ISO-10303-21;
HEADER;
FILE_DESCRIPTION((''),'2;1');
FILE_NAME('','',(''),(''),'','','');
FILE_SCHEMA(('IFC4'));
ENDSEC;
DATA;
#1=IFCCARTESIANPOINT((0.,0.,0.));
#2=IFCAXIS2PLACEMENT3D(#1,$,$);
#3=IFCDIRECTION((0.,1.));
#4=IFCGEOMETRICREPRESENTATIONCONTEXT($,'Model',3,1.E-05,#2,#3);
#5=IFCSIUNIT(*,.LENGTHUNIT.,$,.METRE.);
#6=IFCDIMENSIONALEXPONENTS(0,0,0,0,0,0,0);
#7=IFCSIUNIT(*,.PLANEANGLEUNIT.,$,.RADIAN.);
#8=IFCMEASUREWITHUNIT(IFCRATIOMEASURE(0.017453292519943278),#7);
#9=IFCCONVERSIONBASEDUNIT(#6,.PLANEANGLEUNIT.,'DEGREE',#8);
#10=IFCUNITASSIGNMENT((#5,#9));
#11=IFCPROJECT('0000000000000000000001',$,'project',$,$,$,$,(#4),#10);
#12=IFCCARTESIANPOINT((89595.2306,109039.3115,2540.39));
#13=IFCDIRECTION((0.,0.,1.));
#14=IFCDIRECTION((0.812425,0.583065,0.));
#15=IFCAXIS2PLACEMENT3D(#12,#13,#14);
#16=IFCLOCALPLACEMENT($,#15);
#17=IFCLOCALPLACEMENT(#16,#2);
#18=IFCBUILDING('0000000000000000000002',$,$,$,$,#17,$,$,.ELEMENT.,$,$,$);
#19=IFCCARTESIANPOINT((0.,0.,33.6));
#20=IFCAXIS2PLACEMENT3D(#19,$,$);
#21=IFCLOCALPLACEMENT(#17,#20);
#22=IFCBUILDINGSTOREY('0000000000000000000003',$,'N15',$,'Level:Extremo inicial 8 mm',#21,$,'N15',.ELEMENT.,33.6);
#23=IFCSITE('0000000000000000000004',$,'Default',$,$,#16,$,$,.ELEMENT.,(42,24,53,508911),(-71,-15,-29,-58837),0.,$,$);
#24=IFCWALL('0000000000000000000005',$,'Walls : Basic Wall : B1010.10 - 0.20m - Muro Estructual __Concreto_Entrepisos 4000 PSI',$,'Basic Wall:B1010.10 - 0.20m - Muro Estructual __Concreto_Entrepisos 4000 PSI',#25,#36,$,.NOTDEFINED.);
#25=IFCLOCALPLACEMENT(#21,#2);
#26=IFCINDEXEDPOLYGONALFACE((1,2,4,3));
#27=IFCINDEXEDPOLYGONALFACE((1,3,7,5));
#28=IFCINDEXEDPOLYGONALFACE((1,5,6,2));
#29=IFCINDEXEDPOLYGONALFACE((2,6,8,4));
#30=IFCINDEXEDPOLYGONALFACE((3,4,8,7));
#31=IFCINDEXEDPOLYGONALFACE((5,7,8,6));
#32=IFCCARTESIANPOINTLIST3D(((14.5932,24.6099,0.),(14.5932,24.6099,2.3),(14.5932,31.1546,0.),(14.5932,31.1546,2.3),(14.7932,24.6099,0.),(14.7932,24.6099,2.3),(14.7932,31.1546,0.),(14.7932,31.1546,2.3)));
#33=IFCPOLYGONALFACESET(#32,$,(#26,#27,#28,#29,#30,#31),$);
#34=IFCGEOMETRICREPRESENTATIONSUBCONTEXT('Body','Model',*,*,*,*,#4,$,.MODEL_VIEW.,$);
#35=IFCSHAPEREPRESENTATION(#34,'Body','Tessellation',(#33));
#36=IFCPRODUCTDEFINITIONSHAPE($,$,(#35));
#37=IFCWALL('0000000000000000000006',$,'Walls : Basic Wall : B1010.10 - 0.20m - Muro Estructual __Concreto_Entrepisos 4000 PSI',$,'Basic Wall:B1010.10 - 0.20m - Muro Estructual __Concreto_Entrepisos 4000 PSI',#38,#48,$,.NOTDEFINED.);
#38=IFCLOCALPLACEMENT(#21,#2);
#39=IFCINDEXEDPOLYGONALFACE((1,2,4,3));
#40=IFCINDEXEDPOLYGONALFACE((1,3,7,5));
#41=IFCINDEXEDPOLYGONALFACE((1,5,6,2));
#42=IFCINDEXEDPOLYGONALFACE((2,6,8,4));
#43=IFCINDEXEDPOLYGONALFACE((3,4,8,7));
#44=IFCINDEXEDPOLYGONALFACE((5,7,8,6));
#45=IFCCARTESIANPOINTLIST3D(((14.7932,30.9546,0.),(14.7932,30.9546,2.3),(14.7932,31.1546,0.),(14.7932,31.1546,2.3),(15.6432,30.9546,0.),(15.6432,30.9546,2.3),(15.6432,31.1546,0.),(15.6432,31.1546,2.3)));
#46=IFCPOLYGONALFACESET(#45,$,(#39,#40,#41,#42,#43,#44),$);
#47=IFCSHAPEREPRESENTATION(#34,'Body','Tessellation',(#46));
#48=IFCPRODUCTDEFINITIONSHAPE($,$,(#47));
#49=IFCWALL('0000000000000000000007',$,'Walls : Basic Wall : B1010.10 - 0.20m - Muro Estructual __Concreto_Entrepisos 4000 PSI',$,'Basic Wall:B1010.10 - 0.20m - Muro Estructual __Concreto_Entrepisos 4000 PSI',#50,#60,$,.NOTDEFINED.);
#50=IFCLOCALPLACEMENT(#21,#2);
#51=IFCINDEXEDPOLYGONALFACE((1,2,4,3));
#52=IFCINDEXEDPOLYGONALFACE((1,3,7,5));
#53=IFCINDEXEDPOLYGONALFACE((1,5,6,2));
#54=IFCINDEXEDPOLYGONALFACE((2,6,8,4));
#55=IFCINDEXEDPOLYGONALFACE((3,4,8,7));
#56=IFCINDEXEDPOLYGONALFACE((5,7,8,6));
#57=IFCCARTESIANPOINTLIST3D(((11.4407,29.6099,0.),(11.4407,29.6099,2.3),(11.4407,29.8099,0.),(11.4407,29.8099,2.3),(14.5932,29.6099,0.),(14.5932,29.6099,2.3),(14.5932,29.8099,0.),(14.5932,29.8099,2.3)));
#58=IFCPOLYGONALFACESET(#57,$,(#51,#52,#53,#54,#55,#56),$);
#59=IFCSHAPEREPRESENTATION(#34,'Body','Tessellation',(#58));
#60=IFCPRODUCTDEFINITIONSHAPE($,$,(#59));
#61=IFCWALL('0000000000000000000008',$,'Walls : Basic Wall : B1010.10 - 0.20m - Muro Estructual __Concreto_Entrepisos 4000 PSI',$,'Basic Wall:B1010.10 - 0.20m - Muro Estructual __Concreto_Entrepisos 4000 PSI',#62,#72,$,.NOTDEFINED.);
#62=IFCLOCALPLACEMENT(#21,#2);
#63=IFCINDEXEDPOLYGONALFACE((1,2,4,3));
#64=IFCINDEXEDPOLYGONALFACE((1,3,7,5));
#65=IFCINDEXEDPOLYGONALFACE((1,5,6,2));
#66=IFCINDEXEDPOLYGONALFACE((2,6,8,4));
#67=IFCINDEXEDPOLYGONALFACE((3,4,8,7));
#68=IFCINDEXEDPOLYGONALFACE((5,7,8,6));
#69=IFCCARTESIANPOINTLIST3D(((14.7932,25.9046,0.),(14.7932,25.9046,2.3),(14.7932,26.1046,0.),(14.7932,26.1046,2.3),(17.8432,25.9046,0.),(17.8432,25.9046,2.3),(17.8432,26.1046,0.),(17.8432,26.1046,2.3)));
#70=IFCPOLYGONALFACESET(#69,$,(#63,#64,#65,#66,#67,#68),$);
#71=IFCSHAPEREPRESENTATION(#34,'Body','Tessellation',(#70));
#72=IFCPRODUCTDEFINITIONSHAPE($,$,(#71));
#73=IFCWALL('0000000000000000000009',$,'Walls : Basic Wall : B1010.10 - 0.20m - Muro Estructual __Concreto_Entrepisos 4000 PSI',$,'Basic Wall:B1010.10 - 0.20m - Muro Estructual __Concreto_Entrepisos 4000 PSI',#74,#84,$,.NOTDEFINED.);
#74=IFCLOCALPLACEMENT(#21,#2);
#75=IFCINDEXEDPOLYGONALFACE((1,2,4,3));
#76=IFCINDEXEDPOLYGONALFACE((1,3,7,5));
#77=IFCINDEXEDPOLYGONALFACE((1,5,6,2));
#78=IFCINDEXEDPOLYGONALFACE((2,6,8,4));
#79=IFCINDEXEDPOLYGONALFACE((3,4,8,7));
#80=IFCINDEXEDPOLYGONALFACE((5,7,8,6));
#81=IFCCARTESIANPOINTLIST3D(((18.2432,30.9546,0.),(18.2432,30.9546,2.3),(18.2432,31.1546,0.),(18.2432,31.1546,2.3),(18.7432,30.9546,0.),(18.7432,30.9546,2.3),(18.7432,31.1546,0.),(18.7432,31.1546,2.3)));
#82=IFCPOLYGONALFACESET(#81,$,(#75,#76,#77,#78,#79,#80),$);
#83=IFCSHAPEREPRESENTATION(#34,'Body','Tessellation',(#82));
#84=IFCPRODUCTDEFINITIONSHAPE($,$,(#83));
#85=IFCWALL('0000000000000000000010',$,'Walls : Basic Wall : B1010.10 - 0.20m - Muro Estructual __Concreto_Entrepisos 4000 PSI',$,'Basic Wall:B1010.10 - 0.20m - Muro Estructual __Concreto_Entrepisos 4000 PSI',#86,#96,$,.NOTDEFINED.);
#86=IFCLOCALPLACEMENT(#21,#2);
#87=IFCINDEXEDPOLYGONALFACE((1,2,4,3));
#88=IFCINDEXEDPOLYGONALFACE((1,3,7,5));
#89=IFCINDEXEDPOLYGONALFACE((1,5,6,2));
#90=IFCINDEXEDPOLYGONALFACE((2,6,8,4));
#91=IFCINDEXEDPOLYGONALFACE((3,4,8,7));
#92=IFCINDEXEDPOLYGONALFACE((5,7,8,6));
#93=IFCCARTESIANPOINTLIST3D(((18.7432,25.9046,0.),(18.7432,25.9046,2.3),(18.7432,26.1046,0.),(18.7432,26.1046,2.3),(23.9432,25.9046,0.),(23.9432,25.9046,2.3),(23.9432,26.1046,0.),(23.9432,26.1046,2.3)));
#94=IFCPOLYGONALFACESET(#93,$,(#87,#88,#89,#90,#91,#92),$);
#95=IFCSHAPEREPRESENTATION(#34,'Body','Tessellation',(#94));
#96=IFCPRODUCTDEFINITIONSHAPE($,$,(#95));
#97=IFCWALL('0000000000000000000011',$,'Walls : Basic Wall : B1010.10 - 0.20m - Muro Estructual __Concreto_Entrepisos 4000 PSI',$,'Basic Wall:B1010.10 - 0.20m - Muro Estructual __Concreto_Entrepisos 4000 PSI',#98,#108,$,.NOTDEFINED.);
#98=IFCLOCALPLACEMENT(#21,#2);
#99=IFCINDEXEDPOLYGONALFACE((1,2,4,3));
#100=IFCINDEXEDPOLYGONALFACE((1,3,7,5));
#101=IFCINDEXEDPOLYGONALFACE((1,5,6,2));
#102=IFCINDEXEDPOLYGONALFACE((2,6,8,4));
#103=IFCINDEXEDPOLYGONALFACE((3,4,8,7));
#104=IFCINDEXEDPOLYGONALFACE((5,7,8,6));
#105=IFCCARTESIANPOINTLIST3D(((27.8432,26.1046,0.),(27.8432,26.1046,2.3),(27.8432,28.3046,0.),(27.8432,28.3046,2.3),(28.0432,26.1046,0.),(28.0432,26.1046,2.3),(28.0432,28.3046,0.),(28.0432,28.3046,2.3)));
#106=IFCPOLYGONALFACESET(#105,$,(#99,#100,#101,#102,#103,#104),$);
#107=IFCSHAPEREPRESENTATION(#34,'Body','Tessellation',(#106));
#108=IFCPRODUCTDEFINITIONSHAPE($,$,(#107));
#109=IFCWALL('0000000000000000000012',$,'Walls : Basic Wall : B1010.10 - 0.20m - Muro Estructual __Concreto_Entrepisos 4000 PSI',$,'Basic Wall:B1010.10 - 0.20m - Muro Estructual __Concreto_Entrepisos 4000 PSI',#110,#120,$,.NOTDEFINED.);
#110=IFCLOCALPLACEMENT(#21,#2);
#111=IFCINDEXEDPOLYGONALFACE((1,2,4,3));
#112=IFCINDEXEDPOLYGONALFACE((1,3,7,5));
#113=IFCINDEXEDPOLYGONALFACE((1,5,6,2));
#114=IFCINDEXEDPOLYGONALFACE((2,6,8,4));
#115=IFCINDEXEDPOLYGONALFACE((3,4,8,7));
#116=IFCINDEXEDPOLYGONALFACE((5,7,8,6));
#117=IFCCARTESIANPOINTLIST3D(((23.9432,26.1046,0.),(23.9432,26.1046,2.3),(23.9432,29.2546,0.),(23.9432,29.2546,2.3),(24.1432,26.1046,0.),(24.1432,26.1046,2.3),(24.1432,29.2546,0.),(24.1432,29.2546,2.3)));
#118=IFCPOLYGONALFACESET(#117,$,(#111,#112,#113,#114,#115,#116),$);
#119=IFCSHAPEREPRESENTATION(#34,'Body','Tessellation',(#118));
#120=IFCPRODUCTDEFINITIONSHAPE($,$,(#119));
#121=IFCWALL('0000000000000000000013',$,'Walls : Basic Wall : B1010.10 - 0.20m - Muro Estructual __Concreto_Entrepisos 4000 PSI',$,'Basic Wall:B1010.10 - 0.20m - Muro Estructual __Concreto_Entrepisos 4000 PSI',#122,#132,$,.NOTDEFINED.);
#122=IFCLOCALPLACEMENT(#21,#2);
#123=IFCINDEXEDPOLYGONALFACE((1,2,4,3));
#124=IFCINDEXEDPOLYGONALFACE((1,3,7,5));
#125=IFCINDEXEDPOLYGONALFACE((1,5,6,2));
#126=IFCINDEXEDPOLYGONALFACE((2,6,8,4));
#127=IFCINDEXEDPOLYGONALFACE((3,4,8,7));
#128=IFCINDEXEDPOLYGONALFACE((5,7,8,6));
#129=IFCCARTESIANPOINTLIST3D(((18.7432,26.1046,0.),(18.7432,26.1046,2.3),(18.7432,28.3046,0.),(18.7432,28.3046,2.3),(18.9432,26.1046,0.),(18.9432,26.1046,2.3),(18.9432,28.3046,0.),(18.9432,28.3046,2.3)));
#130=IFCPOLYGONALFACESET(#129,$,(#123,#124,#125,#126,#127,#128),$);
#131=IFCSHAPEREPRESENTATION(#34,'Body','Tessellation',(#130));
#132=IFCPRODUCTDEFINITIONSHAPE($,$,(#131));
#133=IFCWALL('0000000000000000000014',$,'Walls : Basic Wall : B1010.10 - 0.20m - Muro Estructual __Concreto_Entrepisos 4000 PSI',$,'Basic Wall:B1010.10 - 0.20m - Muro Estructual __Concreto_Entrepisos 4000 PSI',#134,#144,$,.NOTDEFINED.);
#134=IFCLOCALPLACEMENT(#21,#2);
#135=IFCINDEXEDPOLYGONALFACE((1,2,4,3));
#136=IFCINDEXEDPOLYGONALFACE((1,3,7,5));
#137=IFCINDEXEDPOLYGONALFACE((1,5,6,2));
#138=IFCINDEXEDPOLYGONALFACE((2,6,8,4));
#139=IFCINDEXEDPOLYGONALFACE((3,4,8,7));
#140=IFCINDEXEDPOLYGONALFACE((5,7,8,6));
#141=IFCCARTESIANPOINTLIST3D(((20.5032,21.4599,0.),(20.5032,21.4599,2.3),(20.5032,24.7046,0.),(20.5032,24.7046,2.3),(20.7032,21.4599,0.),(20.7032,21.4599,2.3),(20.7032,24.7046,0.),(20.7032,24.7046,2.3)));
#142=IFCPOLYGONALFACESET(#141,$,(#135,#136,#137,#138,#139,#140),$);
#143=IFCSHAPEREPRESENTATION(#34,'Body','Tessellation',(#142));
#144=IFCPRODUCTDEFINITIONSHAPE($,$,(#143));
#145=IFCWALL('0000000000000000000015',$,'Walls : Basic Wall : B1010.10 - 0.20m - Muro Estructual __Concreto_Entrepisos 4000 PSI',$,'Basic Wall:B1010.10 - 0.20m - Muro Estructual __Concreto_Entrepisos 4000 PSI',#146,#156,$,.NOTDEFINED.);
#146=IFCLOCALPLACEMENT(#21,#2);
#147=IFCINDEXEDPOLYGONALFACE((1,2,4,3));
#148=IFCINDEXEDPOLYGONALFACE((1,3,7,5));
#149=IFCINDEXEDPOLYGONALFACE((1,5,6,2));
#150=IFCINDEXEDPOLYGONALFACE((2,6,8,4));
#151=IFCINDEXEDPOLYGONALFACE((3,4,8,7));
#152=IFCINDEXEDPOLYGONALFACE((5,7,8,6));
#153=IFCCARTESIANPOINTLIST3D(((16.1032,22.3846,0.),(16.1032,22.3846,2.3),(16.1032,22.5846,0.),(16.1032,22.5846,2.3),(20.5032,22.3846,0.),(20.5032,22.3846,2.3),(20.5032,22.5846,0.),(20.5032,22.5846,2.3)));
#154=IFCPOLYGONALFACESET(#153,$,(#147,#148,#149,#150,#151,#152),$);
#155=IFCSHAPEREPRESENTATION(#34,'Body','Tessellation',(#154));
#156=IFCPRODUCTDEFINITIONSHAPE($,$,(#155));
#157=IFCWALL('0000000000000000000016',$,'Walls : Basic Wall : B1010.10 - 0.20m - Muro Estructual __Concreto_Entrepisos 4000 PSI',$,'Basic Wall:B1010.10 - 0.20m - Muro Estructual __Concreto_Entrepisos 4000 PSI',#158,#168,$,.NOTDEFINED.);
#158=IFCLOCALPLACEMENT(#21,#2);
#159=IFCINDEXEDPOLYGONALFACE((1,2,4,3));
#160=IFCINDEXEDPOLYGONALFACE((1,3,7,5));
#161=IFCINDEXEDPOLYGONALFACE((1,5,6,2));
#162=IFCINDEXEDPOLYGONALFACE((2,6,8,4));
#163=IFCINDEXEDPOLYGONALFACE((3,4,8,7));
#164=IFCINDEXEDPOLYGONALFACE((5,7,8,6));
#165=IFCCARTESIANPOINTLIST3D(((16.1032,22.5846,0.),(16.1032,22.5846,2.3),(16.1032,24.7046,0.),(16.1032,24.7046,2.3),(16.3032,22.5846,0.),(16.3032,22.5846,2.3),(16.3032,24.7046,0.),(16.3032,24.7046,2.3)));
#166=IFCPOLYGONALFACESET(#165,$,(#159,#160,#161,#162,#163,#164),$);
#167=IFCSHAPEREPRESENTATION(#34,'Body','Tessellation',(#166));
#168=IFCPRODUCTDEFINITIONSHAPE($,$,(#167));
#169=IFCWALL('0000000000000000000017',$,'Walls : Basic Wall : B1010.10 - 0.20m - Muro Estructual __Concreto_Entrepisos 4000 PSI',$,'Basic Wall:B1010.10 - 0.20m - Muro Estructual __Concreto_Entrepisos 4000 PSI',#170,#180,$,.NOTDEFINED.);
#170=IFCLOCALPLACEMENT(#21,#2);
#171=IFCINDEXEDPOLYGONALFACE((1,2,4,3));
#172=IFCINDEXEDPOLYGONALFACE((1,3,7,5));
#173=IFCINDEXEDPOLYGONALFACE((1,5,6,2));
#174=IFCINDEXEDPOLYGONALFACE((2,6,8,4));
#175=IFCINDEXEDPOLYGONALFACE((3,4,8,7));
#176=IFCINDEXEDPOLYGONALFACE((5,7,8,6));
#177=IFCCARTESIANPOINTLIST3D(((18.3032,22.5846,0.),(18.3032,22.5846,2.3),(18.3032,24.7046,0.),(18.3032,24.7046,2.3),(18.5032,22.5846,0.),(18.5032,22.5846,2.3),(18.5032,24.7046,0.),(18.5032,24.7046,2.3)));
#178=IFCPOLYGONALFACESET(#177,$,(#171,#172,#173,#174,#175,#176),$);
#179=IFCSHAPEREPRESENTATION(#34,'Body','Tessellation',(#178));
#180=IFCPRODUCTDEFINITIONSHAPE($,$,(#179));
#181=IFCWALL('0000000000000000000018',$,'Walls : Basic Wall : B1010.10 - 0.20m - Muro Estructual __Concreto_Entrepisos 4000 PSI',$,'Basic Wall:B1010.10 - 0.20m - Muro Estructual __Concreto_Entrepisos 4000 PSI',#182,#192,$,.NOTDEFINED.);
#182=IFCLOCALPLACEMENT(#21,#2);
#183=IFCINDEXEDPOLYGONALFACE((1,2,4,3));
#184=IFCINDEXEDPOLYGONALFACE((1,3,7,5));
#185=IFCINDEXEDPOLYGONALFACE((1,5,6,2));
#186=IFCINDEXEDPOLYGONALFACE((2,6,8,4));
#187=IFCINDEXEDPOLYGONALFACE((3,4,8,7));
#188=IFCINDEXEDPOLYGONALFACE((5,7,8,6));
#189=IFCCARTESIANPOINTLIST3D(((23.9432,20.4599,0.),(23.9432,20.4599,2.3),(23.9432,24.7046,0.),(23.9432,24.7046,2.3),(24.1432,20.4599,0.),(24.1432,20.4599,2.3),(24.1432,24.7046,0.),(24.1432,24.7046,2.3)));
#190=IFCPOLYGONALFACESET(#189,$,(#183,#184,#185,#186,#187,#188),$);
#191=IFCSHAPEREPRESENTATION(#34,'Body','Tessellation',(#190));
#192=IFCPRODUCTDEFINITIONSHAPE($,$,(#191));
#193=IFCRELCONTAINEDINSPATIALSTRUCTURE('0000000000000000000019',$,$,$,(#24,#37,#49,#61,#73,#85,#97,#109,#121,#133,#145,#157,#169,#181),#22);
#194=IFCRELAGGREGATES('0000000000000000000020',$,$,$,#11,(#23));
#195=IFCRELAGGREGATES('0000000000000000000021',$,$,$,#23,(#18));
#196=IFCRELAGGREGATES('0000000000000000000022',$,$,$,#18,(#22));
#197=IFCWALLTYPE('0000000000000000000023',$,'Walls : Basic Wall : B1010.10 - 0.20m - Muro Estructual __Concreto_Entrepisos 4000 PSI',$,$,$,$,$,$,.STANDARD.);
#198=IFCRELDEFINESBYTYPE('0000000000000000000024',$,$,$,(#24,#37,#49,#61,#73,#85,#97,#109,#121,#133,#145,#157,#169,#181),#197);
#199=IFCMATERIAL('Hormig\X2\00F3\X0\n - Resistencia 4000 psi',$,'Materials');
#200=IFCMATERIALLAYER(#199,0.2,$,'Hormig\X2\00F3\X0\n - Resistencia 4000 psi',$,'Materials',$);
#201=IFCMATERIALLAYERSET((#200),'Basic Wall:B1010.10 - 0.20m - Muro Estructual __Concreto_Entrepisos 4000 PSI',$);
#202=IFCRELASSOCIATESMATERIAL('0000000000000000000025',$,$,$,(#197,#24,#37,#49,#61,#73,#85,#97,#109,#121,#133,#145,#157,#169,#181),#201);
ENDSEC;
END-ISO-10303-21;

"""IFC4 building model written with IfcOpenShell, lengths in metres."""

from ifc_helpers import new_model, entity, si_unit, converted_unit, direction, frame, frame_2d, origin, place, context, subcontext, project, spatial, rectangle, extrude, material, layer, layer_set, layer_usage, type_object, element, save


model = new_model("IFC4")

# Units and contexts
model_context = context("Model", 3, precision=1e-05, world=origin(), true_north=direction((0.0, 1.0)))
body_context = subcontext(model_context, "Body", "Model", "MODEL_VIEW")
ifc_project = project(units=[si_unit("LENGTHUNIT", "METRE"), converted_unit("PLANEANGLEUNIT", "DEGREE", entity("IfcRatioMeasure", 0.017453292519943278), si_unit("PLANEANGLEUNIT", "RADIAN"), dimensions=[0, 0, 0, 0, 0, 0, 0])], contexts=[model_context])

# Site, building, storey
site_placement = place(None, frame((89595.2306, 109039.3115, 2540.39), z_axis=(0.0, 0.0, 1.0), x_axis=(0.812425, 0.583065, 0.0)))
site = spatial("IfcSite", under=ifc_project, at=site_placement, Name="Default", CompositionType="ELEMENT", RefLatitude=(42, 24, 53, 508911), RefLongitude=(-71, -15, -29, -58837), RefElevation=0.0)
building_placement = place(site_placement, origin())
building = spatial("IfcBuilding", under=site, at=building_placement, CompositionType="ELEMENT")
storey_placement = place(building_placement, frame((0.0, 0.0, 33.6)))
storey = spatial("IfcBuildingStorey", under=building, at=storey_placement, Name="N15", ObjectType="Level:Extremo inicial 8 mm", LongName="N15", CompositionType="ELEMENT", Elevation=33.6)

# Walls
ifc_material_1 = material(Name="Hormigón - Resistencia 4000 psi", Category="Materials")
ifc_layer_1 = layer(ifc_material_1, 0.2, Name="Hormigón - Resistencia 4000 psi", Category="Materials")
ifc_layer_set_1 = layer_set([ifc_layer_1], Name="Basic Wall:B1010.10 - 0.20m - Muro Estructual __Concreto_Entrepisos 4000 PSI")
ifc_layer_usage_1 = layer_usage(ifc_layer_set_1, "AXIS2", "NEGATIVE", 0.1)
wall_type_1 = type_object("IfcWallType", Name="Walls : Basic Wall : B1010.10 - 0.20m - Muro Estructual __Concreto_Entrepisos 4000 PSI", PredefinedType="STANDARD", material=ifc_layer_set_1)
wall_1_placement = place(storey_placement, frame((14.6932, 24.6099, 0.0), z_axis=(0.0, 0.0, 1.0), x_axis=(0.0, 1.0, 0.0)))
element("IfcWall", 1, at=wall_1_placement, inside=storey, type_object=wall_type_1, material=ifc_layer_usage_1, Name="Walls : Basic Wall : B1010.10 - 0.20m - Muro Estructual __Concreto_Entrepisos 4000 PSI", ObjectType="Basic Wall:B1010.10 - 0.20m - Muro Estructual __Concreto_Entrepisos 4000 PSI", PredefinedType="NOTDEFINED", context=body_context, shape_type="SweptSolid", body=[
    extrude(rectangle(XDim=6.5447, YDim=0.2, at=frame_2d((3.2724, 0.0), x_axis=(-1.0, 0.0))), origin(), (0.0, 0.0, 1.0), 2.3),
])
ifc_layer_usage_2 = layer_usage(ifc_layer_set_1, "AXIS2", "NEGATIVE", 0.1)
wall_2_placement = place(storey_placement, frame((15.6432, 31.0546, 0.0), z_axis=(0.0, 0.0, 1.0), x_axis=(-1.0, 0.0, 0.0)))
element("IfcWall", 2, at=wall_2_placement, inside=storey, type_object=wall_type_1, material=ifc_layer_usage_2, Name="Walls : Basic Wall : B1010.10 - 0.20m - Muro Estructual __Concreto_Entrepisos 4000 PSI", ObjectType="Basic Wall:B1010.10 - 0.20m - Muro Estructual __Concreto_Entrepisos 4000 PSI", PredefinedType="NOTDEFINED", context=body_context, shape_type="SweptSolid", body=[
    extrude(rectangle(XDim=0.85, YDim=0.2, at=frame_2d((0.425, 0.0), x_axis=(-1.0, 0.0))), origin(), (0.0, 0.0, 1.0), 2.3),
])
ifc_layer_usage_3 = layer_usage(ifc_layer_set_1, "AXIS2", "NEGATIVE", 0.1)
wall_3_placement = place(storey_placement, frame((11.4407, 29.7099, 0.0)))
element("IfcWall", 3, at=wall_3_placement, inside=storey, type_object=wall_type_1, material=ifc_layer_usage_3, Name="Walls : Basic Wall : B1010.10 - 0.20m - Muro Estructual __Concreto_Entrepisos 4000 PSI", ObjectType="Basic Wall:B1010.10 - 0.20m - Muro Estructual __Concreto_Entrepisos 4000 PSI", PredefinedType="NOTDEFINED", context=body_context, shape_type="SweptSolid", body=[
    extrude(rectangle(XDim=3.1525, YDim=0.2, at=frame_2d((1.5763, 0.0), x_axis=(-1.0, 0.0))), origin(), (0.0, 0.0, 1.0), 2.3),
])
ifc_layer_usage_4 = layer_usage(ifc_layer_set_1, "AXIS2", "NEGATIVE", 0.1)
wall_4_placement = place(storey_placement, frame((17.8432, 26.0046, 0.0), z_axis=(0.0, 0.0, 1.0), x_axis=(-1.0, 0.0, 0.0)))
element("IfcWall", 4, at=wall_4_placement, inside=storey, type_object=wall_type_1, material=ifc_layer_usage_4, Name="Walls : Basic Wall : B1010.10 - 0.20m - Muro Estructual __Concreto_Entrepisos 4000 PSI", ObjectType="Basic Wall:B1010.10 - 0.20m - Muro Estructual __Concreto_Entrepisos 4000 PSI", PredefinedType="NOTDEFINED", context=body_context, shape_type="SweptSolid", body=[
    extrude(rectangle(XDim=3.05, YDim=0.2, at=frame_2d((1.525, 0.0), x_axis=(-1.0, 0.0))), origin(), (0.0, 0.0, 1.0), 2.3),
])
ifc_layer_usage_5 = layer_usage(ifc_layer_set_1, "AXIS2", "NEGATIVE", 0.1)
wall_5_placement = place(storey_placement, frame((18.7432, 31.0546, 0.0), z_axis=(0.0, 0.0, 1.0), x_axis=(-1.0, 0.0, 0.0)))
element("IfcWall", 5, at=wall_5_placement, inside=storey, type_object=wall_type_1, material=ifc_layer_usage_5, Name="Walls : Basic Wall : B1010.10 - 0.20m - Muro Estructual __Concreto_Entrepisos 4000 PSI", ObjectType="Basic Wall:B1010.10 - 0.20m - Muro Estructual __Concreto_Entrepisos 4000 PSI", PredefinedType="NOTDEFINED", context=body_context, shape_type="SweptSolid", body=[
    extrude(rectangle(XDim=0.5, YDim=0.2, at=frame_2d((0.25, 0.0), x_axis=(-1.0, 0.0))), origin(), (0.0, 0.0, 1.0), 2.3),
])
ifc_layer_usage_6 = layer_usage(ifc_layer_set_1, "AXIS2", "NEGATIVE", 0.1)
wall_6_placement = place(storey_placement, frame((18.7432, 26.0046, 0.0)))
element("IfcWall", 6, at=wall_6_placement, inside=storey, type_object=wall_type_1, material=ifc_layer_usage_6, Name="Walls : Basic Wall : B1010.10 - 0.20m - Muro Estructual __Concreto_Entrepisos 4000 PSI", ObjectType="Basic Wall:B1010.10 - 0.20m - Muro Estructual __Concreto_Entrepisos 4000 PSI", PredefinedType="NOTDEFINED", context=body_context, shape_type="SweptSolid", body=[
    extrude(rectangle(XDim=5.2, YDim=0.2, at=frame_2d((2.6, 0.0), x_axis=(-1.0, 0.0))), origin(), (0.0, 0.0, 1.0), 2.3),
])
ifc_layer_usage_7 = layer_usage(ifc_layer_set_1, "AXIS2", "NEGATIVE", 0.1)
wall_7_placement = place(storey_placement, frame((27.9432, 28.3046, 0.0), z_axis=(0.0, 0.0, 1.0), x_axis=(0.0, -1.0, 0.0)))
element("IfcWall", 7, at=wall_7_placement, inside=storey, type_object=wall_type_1, material=ifc_layer_usage_7, Name="Walls : Basic Wall : B1010.10 - 0.20m - Muro Estructual __Concreto_Entrepisos 4000 PSI", ObjectType="Basic Wall:B1010.10 - 0.20m - Muro Estructual __Concreto_Entrepisos 4000 PSI", PredefinedType="NOTDEFINED", context=body_context, shape_type="SweptSolid", body=[
    extrude(rectangle(XDim=2.2, YDim=0.2, at=frame_2d((1.1, 0.0), x_axis=(-1.0, 0.0))), origin(), (0.0, 0.0, 1.0), 2.3),
])
ifc_layer_usage_8 = layer_usage(ifc_layer_set_1, "AXIS2", "NEGATIVE", 0.1)
wall_8_placement = place(storey_placement, frame((24.0432, 26.1046, 0.0), z_axis=(0.0, 0.0, 1.0), x_axis=(0.0, 1.0, 0.0)))
element("IfcWall", 8, at=wall_8_placement, inside=storey, type_object=wall_type_1, material=ifc_layer_usage_8, Name="Walls : Basic Wall : B1010.10 - 0.20m - Muro Estructual __Concreto_Entrepisos 4000 PSI", ObjectType="Basic Wall:B1010.10 - 0.20m - Muro Estructual __Concreto_Entrepisos 4000 PSI", PredefinedType="NOTDEFINED", context=body_context, shape_type="SweptSolid", body=[
    extrude(rectangle(XDim=3.15, YDim=0.2, at=frame_2d((1.575, 0.0), x_axis=(-1.0, 0.0))), origin(), (0.0, 0.0, 1.0), 2.3),
])
ifc_layer_usage_9 = layer_usage(ifc_layer_set_1, "AXIS2", "NEGATIVE", 0.1)
wall_9_placement = place(storey_placement, frame((18.8432, 28.3046, 0.0), z_axis=(0.0, 0.0, 1.0), x_axis=(0.0, -1.0, 0.0)))
element("IfcWall", 9, at=wall_9_placement, inside=storey, type_object=wall_type_1, material=ifc_layer_usage_9, Name="Walls : Basic Wall : B1010.10 - 0.20m - Muro Estructual __Concreto_Entrepisos 4000 PSI", ObjectType="Basic Wall:B1010.10 - 0.20m - Muro Estructual __Concreto_Entrepisos 4000 PSI", PredefinedType="NOTDEFINED", context=body_context, shape_type="SweptSolid", body=[
    extrude(rectangle(XDim=2.2, YDim=0.2, at=frame_2d((1.1, 0.0), x_axis=(-1.0, 0.0))), origin(), (0.0, 0.0, 1.0), 2.3),
])
ifc_layer_usage_10 = layer_usage(ifc_layer_set_1, "AXIS2", "NEGATIVE", 0.1)
wall_10_placement = place(storey_placement, frame((20.6032, 21.4599, 0.0), z_axis=(0.0, 0.0, 1.0), x_axis=(0.0, 1.0, 0.0)))
element("IfcWall", 10, at=wall_10_placement, inside=storey, type_object=wall_type_1, material=ifc_layer_usage_10, Name="Walls : Basic Wall : B1010.10 - 0.20m - Muro Estructual __Concreto_Entrepisos 4000 PSI", ObjectType="Basic Wall:B1010.10 - 0.20m - Muro Estructual __Concreto_Entrepisos 4000 PSI", PredefinedType="NOTDEFINED", context=body_context, shape_type="SweptSolid", body=[
    extrude(rectangle(XDim=3.2447, YDim=0.2, at=frame_2d((1.6224, 0.0), x_axis=(-1.0, 0.0))), origin(), (0.0, 0.0, 1.0), 2.3),
])
ifc_layer_usage_11 = layer_usage(ifc_layer_set_1, "AXIS2", "NEGATIVE", 0.1)
wall_11_placement = place(storey_placement, frame((20.5032, 22.4846, 0.0), z_axis=(0.0, 0.0, 1.0), x_axis=(-1.0, 0.0, 0.0)))
element("IfcWall", 11, at=wall_11_placement, inside=storey, type_object=wall_type_1, material=ifc_layer_usage_11, Name="Walls : Basic Wall : B1010.10 - 0.20m - Muro Estructual __Concreto_Entrepisos 4000 PSI", ObjectType="Basic Wall:B1010.10 - 0.20m - Muro Estructual __Concreto_Entrepisos 4000 PSI", PredefinedType="NOTDEFINED", context=body_context, shape_type="SweptSolid", body=[
    extrude(rectangle(XDim=4.4, YDim=0.2, at=frame_2d((2.2, 0.0), x_axis=(-1.0, 0.0))), origin(), (0.0, 0.0, 1.0), 2.3),
])
ifc_layer_usage_12 = layer_usage(ifc_layer_set_1, "AXIS2", "NEGATIVE", 0.1)
wall_12_placement = place(storey_placement, frame((16.2032, 22.5846, 0.0), z_axis=(0.0, 0.0, 1.0), x_axis=(0.0, 1.0, 0.0)))
element("IfcWall", 12, at=wall_12_placement, inside=storey, type_object=wall_type_1, material=ifc_layer_usage_12, Name="Walls : Basic Wall : B1010.10 - 0.20m - Muro Estructual __Concreto_Entrepisos 4000 PSI", ObjectType="Basic Wall:B1010.10 - 0.20m - Muro Estructual __Concreto_Entrepisos 4000 PSI", PredefinedType="NOTDEFINED", context=body_context, shape_type="SweptSolid", body=[
    extrude(rectangle(XDim=2.12, YDim=0.2, at=frame_2d((1.06, 0.0), x_axis=(-1.0, 0.0))), origin(), (0.0, 0.0, 1.0), 2.3),
])
ifc_layer_usage_13 = layer_usage(ifc_layer_set_1, "AXIS2", "NEGATIVE", 0.1)
wall_13_placement = place(storey_placement, frame((18.4032, 24.7046, 0.0), z_axis=(0.0, 0.0, 1.0), x_axis=(0.0, -1.0, 0.0)))
element("IfcWall", 13, at=wall_13_placement, inside=storey, type_object=wall_type_1, material=ifc_layer_usage_13, Name="Walls : Basic Wall : B1010.10 - 0.20m - Muro Estructual __Concreto_Entrepisos 4000 PSI", ObjectType="Basic Wall:B1010.10 - 0.20m - Muro Estructual __Concreto_Entrepisos 4000 PSI", PredefinedType="NOTDEFINED", context=body_context, shape_type="SweptSolid", body=[
    extrude(rectangle(XDim=2.12, YDim=0.2, at=frame_2d((1.06, 0.0), x_axis=(-1.0, 0.0))), origin(), (0.0, 0.0, 1.0), 2.3),
])
ifc_layer_usage_14 = layer_usage(ifc_layer_set_1, "AXIS2", "NEGATIVE", 0.1)
wall_14_placement = place(storey_placement, frame((24.0432, 20.4599, 0.0), z_axis=(0.0, 0.0, 1.0), x_axis=(0.0, 1.0, 0.0)))
element("IfcWall", 14, at=wall_14_placement, inside=storey, type_object=wall_type_1, material=ifc_layer_usage_14, Name="Walls : Basic Wall : B1010.10 - 0.20m - Muro Estructual __Concreto_Entrepisos 4000 PSI", ObjectType="Basic Wall:B1010.10 - 0.20m - Muro Estructual __Concreto_Entrepisos 4000 PSI", PredefinedType="NOTDEFINED", context=body_context, shape_type="SweptSolid", body=[
    extrude(rectangle(XDim=4.2447, YDim=0.2, at=frame_2d((2.1224, 0.0), x_axis=(-1.0, 0.0))), origin(), (0.0, 0.0, 1.0), 2.3),
])

save(model, "model.ifc")
